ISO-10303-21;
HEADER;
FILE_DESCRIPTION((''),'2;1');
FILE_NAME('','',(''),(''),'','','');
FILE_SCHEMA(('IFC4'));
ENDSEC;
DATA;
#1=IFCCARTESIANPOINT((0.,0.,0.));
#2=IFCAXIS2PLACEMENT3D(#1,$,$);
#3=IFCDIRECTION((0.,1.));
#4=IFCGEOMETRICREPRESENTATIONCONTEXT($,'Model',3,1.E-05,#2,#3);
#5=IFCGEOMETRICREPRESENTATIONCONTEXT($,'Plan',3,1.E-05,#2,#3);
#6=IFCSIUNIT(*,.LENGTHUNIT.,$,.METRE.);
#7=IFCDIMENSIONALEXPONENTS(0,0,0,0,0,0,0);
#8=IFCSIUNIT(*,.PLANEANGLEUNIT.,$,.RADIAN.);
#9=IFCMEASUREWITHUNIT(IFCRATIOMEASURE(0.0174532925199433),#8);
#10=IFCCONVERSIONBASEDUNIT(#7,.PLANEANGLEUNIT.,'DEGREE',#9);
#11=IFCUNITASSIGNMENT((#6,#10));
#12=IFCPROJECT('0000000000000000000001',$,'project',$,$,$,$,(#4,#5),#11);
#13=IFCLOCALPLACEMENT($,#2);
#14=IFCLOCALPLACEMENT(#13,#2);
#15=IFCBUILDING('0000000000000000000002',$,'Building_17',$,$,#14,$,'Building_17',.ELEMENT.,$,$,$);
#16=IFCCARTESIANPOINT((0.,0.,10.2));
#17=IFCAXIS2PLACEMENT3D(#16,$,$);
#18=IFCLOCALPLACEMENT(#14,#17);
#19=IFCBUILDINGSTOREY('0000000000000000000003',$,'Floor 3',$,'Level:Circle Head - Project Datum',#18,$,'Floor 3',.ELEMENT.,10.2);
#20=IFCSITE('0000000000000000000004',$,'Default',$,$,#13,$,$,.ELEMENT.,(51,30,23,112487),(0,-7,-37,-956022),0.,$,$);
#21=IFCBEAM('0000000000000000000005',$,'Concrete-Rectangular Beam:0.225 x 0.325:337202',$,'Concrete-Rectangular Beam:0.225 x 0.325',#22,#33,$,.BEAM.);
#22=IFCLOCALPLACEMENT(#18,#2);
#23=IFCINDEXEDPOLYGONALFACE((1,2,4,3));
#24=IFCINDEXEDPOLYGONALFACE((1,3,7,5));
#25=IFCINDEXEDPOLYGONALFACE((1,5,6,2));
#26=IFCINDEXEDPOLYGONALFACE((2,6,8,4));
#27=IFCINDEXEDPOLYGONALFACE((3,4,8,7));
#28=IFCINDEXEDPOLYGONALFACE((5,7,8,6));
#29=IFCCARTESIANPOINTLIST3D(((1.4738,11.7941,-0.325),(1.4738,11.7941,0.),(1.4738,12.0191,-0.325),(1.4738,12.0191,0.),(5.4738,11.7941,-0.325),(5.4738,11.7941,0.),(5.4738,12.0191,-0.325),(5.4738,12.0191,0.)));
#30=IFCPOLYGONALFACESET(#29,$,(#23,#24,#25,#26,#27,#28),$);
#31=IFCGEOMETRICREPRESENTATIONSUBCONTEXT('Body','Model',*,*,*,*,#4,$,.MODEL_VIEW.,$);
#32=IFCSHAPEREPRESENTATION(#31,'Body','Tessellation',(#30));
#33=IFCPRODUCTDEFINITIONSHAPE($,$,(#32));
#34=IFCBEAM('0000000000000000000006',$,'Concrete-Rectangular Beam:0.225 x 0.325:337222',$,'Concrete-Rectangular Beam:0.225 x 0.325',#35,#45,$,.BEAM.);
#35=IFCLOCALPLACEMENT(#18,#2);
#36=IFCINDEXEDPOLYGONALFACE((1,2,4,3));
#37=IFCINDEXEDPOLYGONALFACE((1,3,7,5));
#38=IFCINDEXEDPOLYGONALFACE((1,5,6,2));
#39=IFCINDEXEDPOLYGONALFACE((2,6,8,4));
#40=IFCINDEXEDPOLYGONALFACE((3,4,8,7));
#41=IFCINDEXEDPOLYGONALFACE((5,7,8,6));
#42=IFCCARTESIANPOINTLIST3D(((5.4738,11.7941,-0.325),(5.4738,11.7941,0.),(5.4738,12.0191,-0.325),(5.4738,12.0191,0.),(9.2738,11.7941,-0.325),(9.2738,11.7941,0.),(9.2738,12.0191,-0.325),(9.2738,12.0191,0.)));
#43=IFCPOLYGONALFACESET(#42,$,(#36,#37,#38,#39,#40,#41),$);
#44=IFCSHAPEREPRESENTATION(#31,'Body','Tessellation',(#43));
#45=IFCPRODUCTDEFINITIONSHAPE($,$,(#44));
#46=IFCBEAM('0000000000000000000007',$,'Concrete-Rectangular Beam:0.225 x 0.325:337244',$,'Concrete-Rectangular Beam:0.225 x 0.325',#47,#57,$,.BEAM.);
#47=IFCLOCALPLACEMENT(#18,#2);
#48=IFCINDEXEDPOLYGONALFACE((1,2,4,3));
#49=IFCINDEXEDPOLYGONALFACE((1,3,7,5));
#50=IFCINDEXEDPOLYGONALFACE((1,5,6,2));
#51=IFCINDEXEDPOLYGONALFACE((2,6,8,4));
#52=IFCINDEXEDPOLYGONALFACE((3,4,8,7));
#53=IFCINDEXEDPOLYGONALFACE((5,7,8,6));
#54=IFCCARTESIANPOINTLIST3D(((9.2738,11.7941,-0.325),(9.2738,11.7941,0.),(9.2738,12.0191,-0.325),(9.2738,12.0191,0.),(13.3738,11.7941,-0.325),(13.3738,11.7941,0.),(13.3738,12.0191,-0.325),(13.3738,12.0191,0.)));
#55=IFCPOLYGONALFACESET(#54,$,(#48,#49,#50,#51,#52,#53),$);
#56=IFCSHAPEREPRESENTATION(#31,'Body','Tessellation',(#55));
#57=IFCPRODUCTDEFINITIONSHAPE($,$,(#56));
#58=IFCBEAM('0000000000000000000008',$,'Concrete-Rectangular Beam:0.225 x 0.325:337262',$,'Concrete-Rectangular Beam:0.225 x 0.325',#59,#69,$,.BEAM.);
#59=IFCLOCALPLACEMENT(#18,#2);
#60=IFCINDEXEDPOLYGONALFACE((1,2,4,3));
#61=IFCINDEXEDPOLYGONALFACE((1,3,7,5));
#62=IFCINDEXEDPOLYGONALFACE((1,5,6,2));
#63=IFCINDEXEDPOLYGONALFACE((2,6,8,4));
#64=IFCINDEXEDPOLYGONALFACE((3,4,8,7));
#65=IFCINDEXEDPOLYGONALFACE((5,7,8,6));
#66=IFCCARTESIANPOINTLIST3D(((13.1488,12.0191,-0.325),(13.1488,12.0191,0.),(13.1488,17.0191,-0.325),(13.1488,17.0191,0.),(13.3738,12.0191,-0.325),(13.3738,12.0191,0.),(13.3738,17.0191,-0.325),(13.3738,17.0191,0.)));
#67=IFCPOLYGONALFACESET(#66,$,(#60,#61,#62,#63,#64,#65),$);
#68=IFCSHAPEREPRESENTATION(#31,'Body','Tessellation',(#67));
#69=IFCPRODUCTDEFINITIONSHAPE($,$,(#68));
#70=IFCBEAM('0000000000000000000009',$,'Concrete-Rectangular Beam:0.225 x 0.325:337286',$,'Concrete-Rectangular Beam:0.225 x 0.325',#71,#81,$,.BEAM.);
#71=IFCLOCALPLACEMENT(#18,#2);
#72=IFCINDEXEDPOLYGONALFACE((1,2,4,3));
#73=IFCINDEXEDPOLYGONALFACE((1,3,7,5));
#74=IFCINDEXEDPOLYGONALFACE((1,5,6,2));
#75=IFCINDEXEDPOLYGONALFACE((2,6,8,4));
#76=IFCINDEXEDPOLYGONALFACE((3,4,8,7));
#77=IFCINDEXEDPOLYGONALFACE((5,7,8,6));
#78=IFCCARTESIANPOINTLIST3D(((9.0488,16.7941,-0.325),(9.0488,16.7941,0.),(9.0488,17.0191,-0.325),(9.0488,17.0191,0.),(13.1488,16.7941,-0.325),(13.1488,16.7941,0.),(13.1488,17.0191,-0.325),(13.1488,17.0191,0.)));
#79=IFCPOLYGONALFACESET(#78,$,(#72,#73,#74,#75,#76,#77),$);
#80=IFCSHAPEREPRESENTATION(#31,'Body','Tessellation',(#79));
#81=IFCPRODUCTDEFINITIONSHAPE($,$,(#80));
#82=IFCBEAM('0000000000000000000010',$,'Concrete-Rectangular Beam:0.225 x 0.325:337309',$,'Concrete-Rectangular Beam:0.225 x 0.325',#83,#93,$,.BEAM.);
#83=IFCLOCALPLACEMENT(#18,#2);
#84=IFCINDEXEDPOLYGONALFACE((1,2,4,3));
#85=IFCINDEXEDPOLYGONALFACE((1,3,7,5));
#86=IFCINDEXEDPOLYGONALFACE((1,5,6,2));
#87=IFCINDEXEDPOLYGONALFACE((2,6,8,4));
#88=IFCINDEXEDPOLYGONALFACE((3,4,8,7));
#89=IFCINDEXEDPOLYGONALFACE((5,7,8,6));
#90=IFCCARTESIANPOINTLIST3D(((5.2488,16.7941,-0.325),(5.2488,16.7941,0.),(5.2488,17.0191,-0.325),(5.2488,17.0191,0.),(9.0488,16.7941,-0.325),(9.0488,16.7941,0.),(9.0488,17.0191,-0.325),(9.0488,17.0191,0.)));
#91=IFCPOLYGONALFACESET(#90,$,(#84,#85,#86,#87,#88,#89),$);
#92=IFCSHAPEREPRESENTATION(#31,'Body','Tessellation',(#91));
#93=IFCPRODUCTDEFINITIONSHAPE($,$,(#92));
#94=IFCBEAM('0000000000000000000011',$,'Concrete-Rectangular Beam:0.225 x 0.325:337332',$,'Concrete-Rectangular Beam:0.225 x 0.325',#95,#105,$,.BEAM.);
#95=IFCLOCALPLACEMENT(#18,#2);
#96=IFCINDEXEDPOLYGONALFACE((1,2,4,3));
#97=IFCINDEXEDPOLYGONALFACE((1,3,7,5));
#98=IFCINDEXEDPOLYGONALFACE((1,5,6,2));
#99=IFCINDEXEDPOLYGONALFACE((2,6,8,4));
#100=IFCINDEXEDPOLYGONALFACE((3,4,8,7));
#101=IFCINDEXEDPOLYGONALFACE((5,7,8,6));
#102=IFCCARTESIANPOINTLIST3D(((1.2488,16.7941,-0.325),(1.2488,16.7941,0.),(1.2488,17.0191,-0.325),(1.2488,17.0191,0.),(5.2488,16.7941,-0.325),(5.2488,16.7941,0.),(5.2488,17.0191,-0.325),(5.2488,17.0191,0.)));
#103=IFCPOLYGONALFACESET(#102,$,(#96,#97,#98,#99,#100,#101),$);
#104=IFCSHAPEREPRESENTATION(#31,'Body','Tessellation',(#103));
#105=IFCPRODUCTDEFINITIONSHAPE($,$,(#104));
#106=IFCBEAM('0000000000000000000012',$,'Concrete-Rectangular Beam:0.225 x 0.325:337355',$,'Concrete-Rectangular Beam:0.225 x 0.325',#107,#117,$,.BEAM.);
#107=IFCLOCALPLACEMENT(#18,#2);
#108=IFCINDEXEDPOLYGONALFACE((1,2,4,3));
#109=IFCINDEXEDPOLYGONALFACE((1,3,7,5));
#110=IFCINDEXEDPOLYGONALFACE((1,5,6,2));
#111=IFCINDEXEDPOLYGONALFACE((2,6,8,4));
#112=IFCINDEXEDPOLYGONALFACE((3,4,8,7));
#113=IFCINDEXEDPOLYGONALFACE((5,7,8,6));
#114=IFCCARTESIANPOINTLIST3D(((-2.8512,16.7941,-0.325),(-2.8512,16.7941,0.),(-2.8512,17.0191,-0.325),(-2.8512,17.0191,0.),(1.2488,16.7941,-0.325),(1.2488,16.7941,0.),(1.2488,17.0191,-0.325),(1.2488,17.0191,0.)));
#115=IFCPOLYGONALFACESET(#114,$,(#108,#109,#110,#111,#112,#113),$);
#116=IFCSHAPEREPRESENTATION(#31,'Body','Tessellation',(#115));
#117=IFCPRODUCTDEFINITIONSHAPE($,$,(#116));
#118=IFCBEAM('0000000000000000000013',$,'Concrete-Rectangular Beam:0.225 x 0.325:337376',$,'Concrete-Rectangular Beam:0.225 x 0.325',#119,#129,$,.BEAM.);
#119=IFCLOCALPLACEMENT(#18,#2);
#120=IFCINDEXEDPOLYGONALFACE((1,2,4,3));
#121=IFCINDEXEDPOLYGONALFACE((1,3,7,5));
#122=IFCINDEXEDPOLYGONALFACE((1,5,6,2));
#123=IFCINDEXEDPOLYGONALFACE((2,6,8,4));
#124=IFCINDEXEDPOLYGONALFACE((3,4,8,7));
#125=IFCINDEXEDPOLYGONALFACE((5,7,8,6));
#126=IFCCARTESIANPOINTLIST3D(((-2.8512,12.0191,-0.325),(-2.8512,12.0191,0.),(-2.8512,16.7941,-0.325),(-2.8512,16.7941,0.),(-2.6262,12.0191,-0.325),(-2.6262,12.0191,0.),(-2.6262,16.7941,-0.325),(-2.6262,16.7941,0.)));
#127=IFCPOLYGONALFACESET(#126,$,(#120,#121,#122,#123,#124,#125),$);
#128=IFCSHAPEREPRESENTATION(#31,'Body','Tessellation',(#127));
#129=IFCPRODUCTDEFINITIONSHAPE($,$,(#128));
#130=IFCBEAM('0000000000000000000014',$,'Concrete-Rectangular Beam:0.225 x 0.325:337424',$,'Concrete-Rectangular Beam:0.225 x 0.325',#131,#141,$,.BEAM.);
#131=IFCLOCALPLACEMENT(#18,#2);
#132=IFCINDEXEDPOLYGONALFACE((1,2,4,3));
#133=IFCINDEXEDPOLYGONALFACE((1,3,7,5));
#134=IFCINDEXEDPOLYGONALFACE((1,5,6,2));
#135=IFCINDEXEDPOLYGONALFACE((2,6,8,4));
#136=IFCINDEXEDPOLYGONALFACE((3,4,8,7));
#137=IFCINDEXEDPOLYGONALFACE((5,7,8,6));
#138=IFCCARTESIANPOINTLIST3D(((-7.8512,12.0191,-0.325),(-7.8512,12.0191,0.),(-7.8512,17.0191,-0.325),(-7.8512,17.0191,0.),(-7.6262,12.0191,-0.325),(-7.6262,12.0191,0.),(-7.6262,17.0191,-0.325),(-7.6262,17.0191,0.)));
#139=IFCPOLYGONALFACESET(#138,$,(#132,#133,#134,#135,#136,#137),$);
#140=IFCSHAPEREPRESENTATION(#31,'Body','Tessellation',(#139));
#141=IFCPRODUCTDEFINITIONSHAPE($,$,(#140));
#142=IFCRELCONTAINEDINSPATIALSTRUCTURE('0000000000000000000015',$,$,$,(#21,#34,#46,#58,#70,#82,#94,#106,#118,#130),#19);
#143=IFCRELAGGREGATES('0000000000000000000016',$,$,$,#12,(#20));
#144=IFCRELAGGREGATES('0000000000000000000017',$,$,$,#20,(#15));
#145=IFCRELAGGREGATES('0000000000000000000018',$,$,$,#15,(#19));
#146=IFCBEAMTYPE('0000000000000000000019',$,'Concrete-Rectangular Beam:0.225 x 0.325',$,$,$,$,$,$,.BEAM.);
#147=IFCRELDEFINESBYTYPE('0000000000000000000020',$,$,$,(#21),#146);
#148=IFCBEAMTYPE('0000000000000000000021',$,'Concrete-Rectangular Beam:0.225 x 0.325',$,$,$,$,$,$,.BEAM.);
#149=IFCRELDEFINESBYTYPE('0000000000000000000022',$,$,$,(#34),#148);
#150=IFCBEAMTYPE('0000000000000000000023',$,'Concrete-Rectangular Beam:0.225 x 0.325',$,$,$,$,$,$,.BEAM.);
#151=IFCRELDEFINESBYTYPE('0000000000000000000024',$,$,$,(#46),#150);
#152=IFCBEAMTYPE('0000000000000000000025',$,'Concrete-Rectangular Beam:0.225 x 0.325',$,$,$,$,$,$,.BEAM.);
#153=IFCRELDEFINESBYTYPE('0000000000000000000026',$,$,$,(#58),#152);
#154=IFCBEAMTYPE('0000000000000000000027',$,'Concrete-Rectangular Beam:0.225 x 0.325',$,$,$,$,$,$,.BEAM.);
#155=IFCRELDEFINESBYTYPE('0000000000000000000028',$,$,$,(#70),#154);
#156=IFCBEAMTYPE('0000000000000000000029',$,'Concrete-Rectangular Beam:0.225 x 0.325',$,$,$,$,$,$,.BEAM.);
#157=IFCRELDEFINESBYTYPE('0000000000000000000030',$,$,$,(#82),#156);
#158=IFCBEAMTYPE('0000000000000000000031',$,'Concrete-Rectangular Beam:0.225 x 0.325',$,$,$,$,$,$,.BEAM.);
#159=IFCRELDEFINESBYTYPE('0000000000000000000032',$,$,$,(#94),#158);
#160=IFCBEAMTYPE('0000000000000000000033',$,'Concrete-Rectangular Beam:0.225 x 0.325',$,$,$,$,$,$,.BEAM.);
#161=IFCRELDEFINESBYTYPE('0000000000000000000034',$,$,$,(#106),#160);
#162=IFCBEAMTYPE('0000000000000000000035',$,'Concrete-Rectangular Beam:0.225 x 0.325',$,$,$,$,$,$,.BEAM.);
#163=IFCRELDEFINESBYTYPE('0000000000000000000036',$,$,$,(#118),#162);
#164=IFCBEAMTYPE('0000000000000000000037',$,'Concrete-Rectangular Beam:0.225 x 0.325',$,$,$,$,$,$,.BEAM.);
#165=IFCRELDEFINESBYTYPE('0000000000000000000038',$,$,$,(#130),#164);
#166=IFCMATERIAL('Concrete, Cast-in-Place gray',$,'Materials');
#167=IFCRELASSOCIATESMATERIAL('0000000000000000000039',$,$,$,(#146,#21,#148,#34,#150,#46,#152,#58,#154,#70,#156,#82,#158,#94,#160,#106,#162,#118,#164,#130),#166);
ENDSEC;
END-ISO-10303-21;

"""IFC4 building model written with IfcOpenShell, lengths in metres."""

from ifc_helpers import new_model, entity, si_unit, converted_unit, direction, frame, origin, place, context, subcontext, project, spatial, indexed_curve, outline, extrude, source, transform, mapped, material, type_object, type_shapes, element, save


model = new_model("IFC4")

# Units and contexts
model_context = context("Model", 3, precision=1e-05, world=origin(), true_north=direction((0.0, 1.0)))
plan_context = context("Plan", 3, precision=1e-05, world=origin(), true_north=direction((0.0, 1.0)))
body_context = subcontext(model_context, "Body", "Model", "MODEL_VIEW")
ifc_project = project(units=[si_unit("LENGTHUNIT", "METRE"), converted_unit("PLANEANGLEUNIT", "DEGREE", entity("IfcRatioMeasure", 0.0174532925199433), si_unit("PLANEANGLEUNIT", "RADIAN"), dimensions=[0, 0, 0, 0, 0, 0, 0])], contexts=[model_context, plan_context])

# Site, building, storey
site_placement = place(None, origin())
site = spatial("IfcSite", under=ifc_project, at=site_placement, Name="Default", CompositionType="ELEMENT", RefLatitude=(51, 30, 23, 112487), RefLongitude=(0, -7, -37, -956022), RefElevation=0.0)
building_placement = place(site_placement, origin())
building = spatial("IfcBuilding", under=site, at=building_placement, Name="Building_17", LongName="Building_17", CompositionType="ELEMENT")
storey_placement = place(building_placement, frame((0.0, 0.0, 10.2)))
storey = spatial("IfcBuildingStorey", under=building, at=storey_placement, Name="Floor 3", ObjectType="Level:Circle Head - Project Datum", LongName="Floor 3", CompositionType="ELEMENT", Elevation=10.2)

# Beams
ifc_material = material(Name="Concrete, Cast-in-Place gray", Category="Materials")
beam_type_1 = type_object("IfcBeamType", Name="Concrete-Rectangular Beam:0.225 x 0.325", PredefinedType="BEAM", material=ifc_material)
shared_shape_1 = source(origin(), body_context, "Body", "SweptSolid", [
    extrude(outline(indexed_curve([(-0.1625, -0.1125), (0.1625, -0.1125), (0.1625, 0.1125), (-0.1625, 0.1125), (-0.1625, -0.1125)], self_intersect=False)), frame((1.4738, 11.9066, 10.0375), z_axis=(1.0, 0.0, 0.0), x_axis=(0.0, 0.0, -1.0)), (0.0, 0.0, 1.0), 4.0),
])
type_shapes(beam_type_1, [shared_shape_1])
beam_1_placement = place(storey_placement, frame((0.0, 0.0, -10.2)))
element("IfcBeam", 1, at=beam_1_placement, inside=storey, type_object=beam_type_1, material=ifc_material, Name="Concrete-Rectangular Beam:0.225 x 0.325:337202", ObjectType="Concrete-Rectangular Beam:0.225 x 0.325", PredefinedType="BEAM", context=body_context, shape_type="MappedRepresentation", body=[
    mapped(shared_shape_1, transform((0.0, 0.0, 0.0), scale=1.0)),
])
beam_type_2 = type_object("IfcBeamType", Name="Concrete-Rectangular Beam:0.225 x 0.325", PredefinedType="BEAM", material=ifc_material)
shared_shape_2 = source(origin(), body_context, "Body", "SweptSolid", [
    extrude(outline(indexed_curve([(-0.1625, -0.1125), (0.1625, -0.1125), (0.1625, 0.1125), (-0.1625, 0.1125), (-0.1625, -0.1125)], self_intersect=False)), frame((5.4738, 11.9066, 10.0375), z_axis=(1.0, 0.0, 0.0), x_axis=(0.0, 0.0, -1.0)), (0.0, 0.0, 1.0), 3.8),
])
type_shapes(beam_type_2, [shared_shape_2])
beam_2_placement = place(storey_placement, frame((0.0, 0.0, -10.2)))
element("IfcBeam", 2, at=beam_2_placement, inside=storey, type_object=beam_type_2, material=ifc_material, Name="Concrete-Rectangular Beam:0.225 x 0.325:337222", ObjectType="Concrete-Rectangular Beam:0.225 x 0.325", PredefinedType="BEAM", context=body_context, shape_type="MappedRepresentation", body=[
    mapped(shared_shape_2, transform((0.0, 0.0, 0.0), scale=1.0)),
])
beam_type_3 = type_object("IfcBeamType", Name="Concrete-Rectangular Beam:0.225 x 0.325", PredefinedType="BEAM", material=ifc_material)
shared_shape_3 = source(origin(), body_context, "Body", "SweptSolid", [
    extrude(outline(indexed_curve([(-0.1625, -0.1125), (0.1625, -0.1125), (0.1625, 0.1125), (-0.1625, 0.1125), (-0.1625, -0.1125)], self_intersect=False)), frame((9.2738, 11.9066, 10.0375), z_axis=(1.0, 0.0, 0.0), x_axis=(0.0, 0.0, -1.0)), (0.0, 0.0, 1.0), 4.1),
])
type_shapes(beam_type_3, [shared_shape_3])
beam_3_placement = place(storey_placement, frame((0.0, 0.0, -10.2)))
element("IfcBeam", 3, at=beam_3_placement, inside=storey, type_object=beam_type_3, material=ifc_material, Name="Concrete-Rectangular Beam:0.225 x 0.325:337244", ObjectType="Concrete-Rectangular Beam:0.225 x 0.325", PredefinedType="BEAM", context=body_context, shape_type="MappedRepresentation", body=[
    mapped(shared_shape_3, transform((0.0, 0.0, 0.0), scale=1.0)),
])
beam_type_4 = type_object("IfcBeamType", Name="Concrete-Rectangular Beam:0.225 x 0.325", PredefinedType="BEAM", material=ifc_material)
shared_shape_4 = source(origin(), body_context, "Body", "SweptSolid", [
    extrude(outline(indexed_curve([(-0.1125, -0.1625), (0.1125, -0.1625), (0.1125, 0.1625), (-0.1125, 0.1625), (-0.1125, -0.1625)], self_intersect=False)), frame((13.2613, 12.0191, 10.0375), z_axis=(0.0, 1.0, 0.0), x_axis=(-1.0, 0.0, 0.0)), (0.0, 0.0, 1.0), 5.0),
])
type_shapes(beam_type_4, [shared_shape_4])
beam_4_placement = place(storey_placement, frame((0.0, 0.0, -10.2)))
element("IfcBeam", 4, at=beam_4_placement, inside=storey, type_object=beam_type_4, material=ifc_material, Name="Concrete-Rectangular Beam:0.225 x 0.325:337262", ObjectType="Concrete-Rectangular Beam:0.225 x 0.325", PredefinedType="BEAM", context=body_context, shape_type="MappedRepresentation", body=[
    mapped(shared_shape_4, transform((0.0, 0.0, 0.0), scale=1.0)),
])
beam_type_5 = type_object("IfcBeamType", Name="Concrete-Rectangular Beam:0.225 x 0.325", PredefinedType="BEAM", material=ifc_material)
shared_shape_5 = source(origin(), body_context, "Body", "SweptSolid", [
    extrude(outline(indexed_curve([(-0.1625, -0.1125), (0.1625, -0.1125), (0.1625, 0.1125), (-0.1625, 0.1125), (-0.1625, -0.1125)], self_intersect=False)), frame((13.1488, 16.9066, 10.0375), z_axis=(-1.0, 0.0, 0.0), x_axis=(0.0, 0.0, -1.0)), (0.0, 0.0, 1.0), 4.1),
])
type_shapes(beam_type_5, [shared_shape_5])
beam_5_placement = place(storey_placement, frame((0.0, 0.0, -10.2)))
element("IfcBeam", 5, at=beam_5_placement, inside=storey, type_object=beam_type_5, material=ifc_material, Name="Concrete-Rectangular Beam:0.225 x 0.325:337286", ObjectType="Concrete-Rectangular Beam:0.225 x 0.325", PredefinedType="BEAM", context=body_context, shape_type="MappedRepresentation", body=[
    mapped(shared_shape_5, transform((0.0, 0.0, 0.0), scale=1.0)),
])
beam_type_6 = type_object("IfcBeamType", Name="Concrete-Rectangular Beam:0.225 x 0.325", PredefinedType="BEAM", material=ifc_material)
shared_shape_6 = source(origin(), body_context, "Body", "SweptSolid", [
    extrude(outline(indexed_curve([(-0.1625, -0.1125), (0.1625, -0.1125), (0.1625, 0.1125), (-0.1625, 0.1125), (-0.1625, -0.1125)], self_intersect=False)), frame((9.0488, 16.9066, 10.0375), z_axis=(-1.0, 0.0, 0.0), x_axis=(0.0, 0.0, -1.0)), (0.0, 0.0, 1.0), 3.8),
])
type_shapes(beam_type_6, [shared_shape_6])
beam_6_placement = place(storey_placement, frame((0.0, 0.0, -10.2)))
element("IfcBeam", 6, at=beam_6_placement, inside=storey, type_object=beam_type_6, material=ifc_material, Name="Concrete-Rectangular Beam:0.225 x 0.325:337309", ObjectType="Concrete-Rectangular Beam:0.225 x 0.325", PredefinedType="BEAM", context=body_context, shape_type="MappedRepresentation", body=[
    mapped(shared_shape_6, transform((0.0, 0.0, 0.0), scale=1.0)),
])
beam_type_7 = type_object("IfcBeamType", Name="Concrete-Rectangular Beam:0.225 x 0.325", PredefinedType="BEAM", material=ifc_material)
shared_shape_7 = source(origin(), body_context, "Body", "SweptSolid", [
    extrude(outline(indexed_curve([(-0.1625, -0.1125), (0.1625, -0.1125), (0.1625, 0.1125), (-0.1625, 0.1125), (-0.1625, -0.1125)], self_intersect=False)), frame((5.2488, 16.9066, 10.0375), z_axis=(-1.0, 0.0, 0.0), x_axis=(0.0, 0.0, -1.0)), (0.0, 0.0, 1.0), 4.0),
])
type_shapes(beam_type_7, [shared_shape_7])
beam_7_placement = place(storey_placement, frame((0.0, 0.0, -10.2)))
element("IfcBeam", 7, at=beam_7_placement, inside=storey, type_object=beam_type_7, material=ifc_material, Name="Concrete-Rectangular Beam:0.225 x 0.325:337332", ObjectType="Concrete-Rectangular Beam:0.225 x 0.325", PredefinedType="BEAM", context=body_context, shape_type="MappedRepresentation", body=[
    mapped(shared_shape_7, transform((0.0, 0.0, 0.0), scale=1.0)),
])
beam_type_8 = type_object("IfcBeamType", Name="Concrete-Rectangular Beam:0.225 x 0.325", PredefinedType="BEAM", material=ifc_material)
shared_shape_8 = source(origin(), body_context, "Body", "SweptSolid", [
    extrude(outline(indexed_curve([(-0.1625, -0.1125), (0.1625, -0.1125), (0.1625, 0.1125), (-0.1625, 0.1125), (-0.1625, -0.1125)], self_intersect=False)), frame((1.2488, 16.9066, 10.0375), z_axis=(-1.0, 0.0, 0.0), x_axis=(0.0, 0.0, -1.0)), (0.0, 0.0, 1.0), 4.1),
])
type_shapes(beam_type_8, [shared_shape_8])
beam_8_placement = place(storey_placement, frame((0.0, 0.0, -10.2)))
element("IfcBeam", 8, at=beam_8_placement, inside=storey, type_object=beam_type_8, material=ifc_material, Name="Concrete-Rectangular Beam:0.225 x 0.325:337355", ObjectType="Concrete-Rectangular Beam:0.225 x 0.325", PredefinedType="BEAM", context=body_context, shape_type="MappedRepresentation", body=[
    mapped(shared_shape_8, transform((0.0, 0.0, 0.0), scale=1.0)),
])
beam_type_9 = type_object("IfcBeamType", Name="Concrete-Rectangular Beam:0.225 x 0.325", PredefinedType="BEAM", material=ifc_material)
shared_shape_9 = source(origin(), body_context, "Body", "SweptSolid", [
    extrude(outline(indexed_curve([(-0.1125, -0.1625), (0.1125, -0.1625), (0.1125, 0.1625), (-0.1125, 0.1625), (-0.1125, -0.1625)], self_intersect=False)), frame((-2.7387, 16.7941, 10.0375), z_axis=(0.0, -1.0, 0.0), x_axis=(-1.0, 0.0, 0.0)), (0.0, 0.0, 1.0), 4.775),
])
type_shapes(beam_type_9, [shared_shape_9])
beam_9_placement = place(storey_placement, frame((0.0, 0.0, -10.2)))
element("IfcBeam", 9, at=beam_9_placement, inside=storey, type_object=beam_type_9, material=ifc_material, Name="Concrete-Rectangular Beam:0.225 x 0.325:337376", ObjectType="Concrete-Rectangular Beam:0.225 x 0.325", PredefinedType="BEAM", context=body_context, shape_type="MappedRepresentation", body=[
    mapped(shared_shape_9, transform((0.0, 0.0, 0.0), scale=1.0)),
])
beam_type_10 = type_object("IfcBeamType", Name="Concrete-Rectangular Beam:0.225 x 0.325", PredefinedType="BEAM", material=ifc_material)
shared_shape_10 = source(origin(), body_context, "Body", "SweptSolid", [
    extrude(outline(indexed_curve([(-0.1125, -0.1625), (0.1125, -0.1625), (0.1125, 0.1625), (-0.1125, 0.1625), (-0.1125, -0.1625)], self_intersect=False)), frame((-7.7387, 17.0191, 10.0375), z_axis=(0.0, -1.0, 0.0), x_axis=(-1.0, 0.0, 0.0)), (0.0, 0.0, 1.0), 5.0),
])
type_shapes(beam_type_10, [shared_shape_10])
beam_10_placement = place(storey_placement, frame((0.0, 0.0, -10.2)))
element("IfcBeam", 10, at=beam_10_placement, inside=storey, type_object=beam_type_10, material=ifc_material, Name="Concrete-Rectangular Beam:0.225 x 0.325:337424", ObjectType="Concrete-Rectangular Beam:0.225 x 0.325", PredefinedType="BEAM", context=body_context, shape_type="MappedRepresentation", body=[
    mapped(shared_shape_10, transform((0.0, 0.0, 0.0), scale=1.0)),
])

save(model, "model.ifc")
